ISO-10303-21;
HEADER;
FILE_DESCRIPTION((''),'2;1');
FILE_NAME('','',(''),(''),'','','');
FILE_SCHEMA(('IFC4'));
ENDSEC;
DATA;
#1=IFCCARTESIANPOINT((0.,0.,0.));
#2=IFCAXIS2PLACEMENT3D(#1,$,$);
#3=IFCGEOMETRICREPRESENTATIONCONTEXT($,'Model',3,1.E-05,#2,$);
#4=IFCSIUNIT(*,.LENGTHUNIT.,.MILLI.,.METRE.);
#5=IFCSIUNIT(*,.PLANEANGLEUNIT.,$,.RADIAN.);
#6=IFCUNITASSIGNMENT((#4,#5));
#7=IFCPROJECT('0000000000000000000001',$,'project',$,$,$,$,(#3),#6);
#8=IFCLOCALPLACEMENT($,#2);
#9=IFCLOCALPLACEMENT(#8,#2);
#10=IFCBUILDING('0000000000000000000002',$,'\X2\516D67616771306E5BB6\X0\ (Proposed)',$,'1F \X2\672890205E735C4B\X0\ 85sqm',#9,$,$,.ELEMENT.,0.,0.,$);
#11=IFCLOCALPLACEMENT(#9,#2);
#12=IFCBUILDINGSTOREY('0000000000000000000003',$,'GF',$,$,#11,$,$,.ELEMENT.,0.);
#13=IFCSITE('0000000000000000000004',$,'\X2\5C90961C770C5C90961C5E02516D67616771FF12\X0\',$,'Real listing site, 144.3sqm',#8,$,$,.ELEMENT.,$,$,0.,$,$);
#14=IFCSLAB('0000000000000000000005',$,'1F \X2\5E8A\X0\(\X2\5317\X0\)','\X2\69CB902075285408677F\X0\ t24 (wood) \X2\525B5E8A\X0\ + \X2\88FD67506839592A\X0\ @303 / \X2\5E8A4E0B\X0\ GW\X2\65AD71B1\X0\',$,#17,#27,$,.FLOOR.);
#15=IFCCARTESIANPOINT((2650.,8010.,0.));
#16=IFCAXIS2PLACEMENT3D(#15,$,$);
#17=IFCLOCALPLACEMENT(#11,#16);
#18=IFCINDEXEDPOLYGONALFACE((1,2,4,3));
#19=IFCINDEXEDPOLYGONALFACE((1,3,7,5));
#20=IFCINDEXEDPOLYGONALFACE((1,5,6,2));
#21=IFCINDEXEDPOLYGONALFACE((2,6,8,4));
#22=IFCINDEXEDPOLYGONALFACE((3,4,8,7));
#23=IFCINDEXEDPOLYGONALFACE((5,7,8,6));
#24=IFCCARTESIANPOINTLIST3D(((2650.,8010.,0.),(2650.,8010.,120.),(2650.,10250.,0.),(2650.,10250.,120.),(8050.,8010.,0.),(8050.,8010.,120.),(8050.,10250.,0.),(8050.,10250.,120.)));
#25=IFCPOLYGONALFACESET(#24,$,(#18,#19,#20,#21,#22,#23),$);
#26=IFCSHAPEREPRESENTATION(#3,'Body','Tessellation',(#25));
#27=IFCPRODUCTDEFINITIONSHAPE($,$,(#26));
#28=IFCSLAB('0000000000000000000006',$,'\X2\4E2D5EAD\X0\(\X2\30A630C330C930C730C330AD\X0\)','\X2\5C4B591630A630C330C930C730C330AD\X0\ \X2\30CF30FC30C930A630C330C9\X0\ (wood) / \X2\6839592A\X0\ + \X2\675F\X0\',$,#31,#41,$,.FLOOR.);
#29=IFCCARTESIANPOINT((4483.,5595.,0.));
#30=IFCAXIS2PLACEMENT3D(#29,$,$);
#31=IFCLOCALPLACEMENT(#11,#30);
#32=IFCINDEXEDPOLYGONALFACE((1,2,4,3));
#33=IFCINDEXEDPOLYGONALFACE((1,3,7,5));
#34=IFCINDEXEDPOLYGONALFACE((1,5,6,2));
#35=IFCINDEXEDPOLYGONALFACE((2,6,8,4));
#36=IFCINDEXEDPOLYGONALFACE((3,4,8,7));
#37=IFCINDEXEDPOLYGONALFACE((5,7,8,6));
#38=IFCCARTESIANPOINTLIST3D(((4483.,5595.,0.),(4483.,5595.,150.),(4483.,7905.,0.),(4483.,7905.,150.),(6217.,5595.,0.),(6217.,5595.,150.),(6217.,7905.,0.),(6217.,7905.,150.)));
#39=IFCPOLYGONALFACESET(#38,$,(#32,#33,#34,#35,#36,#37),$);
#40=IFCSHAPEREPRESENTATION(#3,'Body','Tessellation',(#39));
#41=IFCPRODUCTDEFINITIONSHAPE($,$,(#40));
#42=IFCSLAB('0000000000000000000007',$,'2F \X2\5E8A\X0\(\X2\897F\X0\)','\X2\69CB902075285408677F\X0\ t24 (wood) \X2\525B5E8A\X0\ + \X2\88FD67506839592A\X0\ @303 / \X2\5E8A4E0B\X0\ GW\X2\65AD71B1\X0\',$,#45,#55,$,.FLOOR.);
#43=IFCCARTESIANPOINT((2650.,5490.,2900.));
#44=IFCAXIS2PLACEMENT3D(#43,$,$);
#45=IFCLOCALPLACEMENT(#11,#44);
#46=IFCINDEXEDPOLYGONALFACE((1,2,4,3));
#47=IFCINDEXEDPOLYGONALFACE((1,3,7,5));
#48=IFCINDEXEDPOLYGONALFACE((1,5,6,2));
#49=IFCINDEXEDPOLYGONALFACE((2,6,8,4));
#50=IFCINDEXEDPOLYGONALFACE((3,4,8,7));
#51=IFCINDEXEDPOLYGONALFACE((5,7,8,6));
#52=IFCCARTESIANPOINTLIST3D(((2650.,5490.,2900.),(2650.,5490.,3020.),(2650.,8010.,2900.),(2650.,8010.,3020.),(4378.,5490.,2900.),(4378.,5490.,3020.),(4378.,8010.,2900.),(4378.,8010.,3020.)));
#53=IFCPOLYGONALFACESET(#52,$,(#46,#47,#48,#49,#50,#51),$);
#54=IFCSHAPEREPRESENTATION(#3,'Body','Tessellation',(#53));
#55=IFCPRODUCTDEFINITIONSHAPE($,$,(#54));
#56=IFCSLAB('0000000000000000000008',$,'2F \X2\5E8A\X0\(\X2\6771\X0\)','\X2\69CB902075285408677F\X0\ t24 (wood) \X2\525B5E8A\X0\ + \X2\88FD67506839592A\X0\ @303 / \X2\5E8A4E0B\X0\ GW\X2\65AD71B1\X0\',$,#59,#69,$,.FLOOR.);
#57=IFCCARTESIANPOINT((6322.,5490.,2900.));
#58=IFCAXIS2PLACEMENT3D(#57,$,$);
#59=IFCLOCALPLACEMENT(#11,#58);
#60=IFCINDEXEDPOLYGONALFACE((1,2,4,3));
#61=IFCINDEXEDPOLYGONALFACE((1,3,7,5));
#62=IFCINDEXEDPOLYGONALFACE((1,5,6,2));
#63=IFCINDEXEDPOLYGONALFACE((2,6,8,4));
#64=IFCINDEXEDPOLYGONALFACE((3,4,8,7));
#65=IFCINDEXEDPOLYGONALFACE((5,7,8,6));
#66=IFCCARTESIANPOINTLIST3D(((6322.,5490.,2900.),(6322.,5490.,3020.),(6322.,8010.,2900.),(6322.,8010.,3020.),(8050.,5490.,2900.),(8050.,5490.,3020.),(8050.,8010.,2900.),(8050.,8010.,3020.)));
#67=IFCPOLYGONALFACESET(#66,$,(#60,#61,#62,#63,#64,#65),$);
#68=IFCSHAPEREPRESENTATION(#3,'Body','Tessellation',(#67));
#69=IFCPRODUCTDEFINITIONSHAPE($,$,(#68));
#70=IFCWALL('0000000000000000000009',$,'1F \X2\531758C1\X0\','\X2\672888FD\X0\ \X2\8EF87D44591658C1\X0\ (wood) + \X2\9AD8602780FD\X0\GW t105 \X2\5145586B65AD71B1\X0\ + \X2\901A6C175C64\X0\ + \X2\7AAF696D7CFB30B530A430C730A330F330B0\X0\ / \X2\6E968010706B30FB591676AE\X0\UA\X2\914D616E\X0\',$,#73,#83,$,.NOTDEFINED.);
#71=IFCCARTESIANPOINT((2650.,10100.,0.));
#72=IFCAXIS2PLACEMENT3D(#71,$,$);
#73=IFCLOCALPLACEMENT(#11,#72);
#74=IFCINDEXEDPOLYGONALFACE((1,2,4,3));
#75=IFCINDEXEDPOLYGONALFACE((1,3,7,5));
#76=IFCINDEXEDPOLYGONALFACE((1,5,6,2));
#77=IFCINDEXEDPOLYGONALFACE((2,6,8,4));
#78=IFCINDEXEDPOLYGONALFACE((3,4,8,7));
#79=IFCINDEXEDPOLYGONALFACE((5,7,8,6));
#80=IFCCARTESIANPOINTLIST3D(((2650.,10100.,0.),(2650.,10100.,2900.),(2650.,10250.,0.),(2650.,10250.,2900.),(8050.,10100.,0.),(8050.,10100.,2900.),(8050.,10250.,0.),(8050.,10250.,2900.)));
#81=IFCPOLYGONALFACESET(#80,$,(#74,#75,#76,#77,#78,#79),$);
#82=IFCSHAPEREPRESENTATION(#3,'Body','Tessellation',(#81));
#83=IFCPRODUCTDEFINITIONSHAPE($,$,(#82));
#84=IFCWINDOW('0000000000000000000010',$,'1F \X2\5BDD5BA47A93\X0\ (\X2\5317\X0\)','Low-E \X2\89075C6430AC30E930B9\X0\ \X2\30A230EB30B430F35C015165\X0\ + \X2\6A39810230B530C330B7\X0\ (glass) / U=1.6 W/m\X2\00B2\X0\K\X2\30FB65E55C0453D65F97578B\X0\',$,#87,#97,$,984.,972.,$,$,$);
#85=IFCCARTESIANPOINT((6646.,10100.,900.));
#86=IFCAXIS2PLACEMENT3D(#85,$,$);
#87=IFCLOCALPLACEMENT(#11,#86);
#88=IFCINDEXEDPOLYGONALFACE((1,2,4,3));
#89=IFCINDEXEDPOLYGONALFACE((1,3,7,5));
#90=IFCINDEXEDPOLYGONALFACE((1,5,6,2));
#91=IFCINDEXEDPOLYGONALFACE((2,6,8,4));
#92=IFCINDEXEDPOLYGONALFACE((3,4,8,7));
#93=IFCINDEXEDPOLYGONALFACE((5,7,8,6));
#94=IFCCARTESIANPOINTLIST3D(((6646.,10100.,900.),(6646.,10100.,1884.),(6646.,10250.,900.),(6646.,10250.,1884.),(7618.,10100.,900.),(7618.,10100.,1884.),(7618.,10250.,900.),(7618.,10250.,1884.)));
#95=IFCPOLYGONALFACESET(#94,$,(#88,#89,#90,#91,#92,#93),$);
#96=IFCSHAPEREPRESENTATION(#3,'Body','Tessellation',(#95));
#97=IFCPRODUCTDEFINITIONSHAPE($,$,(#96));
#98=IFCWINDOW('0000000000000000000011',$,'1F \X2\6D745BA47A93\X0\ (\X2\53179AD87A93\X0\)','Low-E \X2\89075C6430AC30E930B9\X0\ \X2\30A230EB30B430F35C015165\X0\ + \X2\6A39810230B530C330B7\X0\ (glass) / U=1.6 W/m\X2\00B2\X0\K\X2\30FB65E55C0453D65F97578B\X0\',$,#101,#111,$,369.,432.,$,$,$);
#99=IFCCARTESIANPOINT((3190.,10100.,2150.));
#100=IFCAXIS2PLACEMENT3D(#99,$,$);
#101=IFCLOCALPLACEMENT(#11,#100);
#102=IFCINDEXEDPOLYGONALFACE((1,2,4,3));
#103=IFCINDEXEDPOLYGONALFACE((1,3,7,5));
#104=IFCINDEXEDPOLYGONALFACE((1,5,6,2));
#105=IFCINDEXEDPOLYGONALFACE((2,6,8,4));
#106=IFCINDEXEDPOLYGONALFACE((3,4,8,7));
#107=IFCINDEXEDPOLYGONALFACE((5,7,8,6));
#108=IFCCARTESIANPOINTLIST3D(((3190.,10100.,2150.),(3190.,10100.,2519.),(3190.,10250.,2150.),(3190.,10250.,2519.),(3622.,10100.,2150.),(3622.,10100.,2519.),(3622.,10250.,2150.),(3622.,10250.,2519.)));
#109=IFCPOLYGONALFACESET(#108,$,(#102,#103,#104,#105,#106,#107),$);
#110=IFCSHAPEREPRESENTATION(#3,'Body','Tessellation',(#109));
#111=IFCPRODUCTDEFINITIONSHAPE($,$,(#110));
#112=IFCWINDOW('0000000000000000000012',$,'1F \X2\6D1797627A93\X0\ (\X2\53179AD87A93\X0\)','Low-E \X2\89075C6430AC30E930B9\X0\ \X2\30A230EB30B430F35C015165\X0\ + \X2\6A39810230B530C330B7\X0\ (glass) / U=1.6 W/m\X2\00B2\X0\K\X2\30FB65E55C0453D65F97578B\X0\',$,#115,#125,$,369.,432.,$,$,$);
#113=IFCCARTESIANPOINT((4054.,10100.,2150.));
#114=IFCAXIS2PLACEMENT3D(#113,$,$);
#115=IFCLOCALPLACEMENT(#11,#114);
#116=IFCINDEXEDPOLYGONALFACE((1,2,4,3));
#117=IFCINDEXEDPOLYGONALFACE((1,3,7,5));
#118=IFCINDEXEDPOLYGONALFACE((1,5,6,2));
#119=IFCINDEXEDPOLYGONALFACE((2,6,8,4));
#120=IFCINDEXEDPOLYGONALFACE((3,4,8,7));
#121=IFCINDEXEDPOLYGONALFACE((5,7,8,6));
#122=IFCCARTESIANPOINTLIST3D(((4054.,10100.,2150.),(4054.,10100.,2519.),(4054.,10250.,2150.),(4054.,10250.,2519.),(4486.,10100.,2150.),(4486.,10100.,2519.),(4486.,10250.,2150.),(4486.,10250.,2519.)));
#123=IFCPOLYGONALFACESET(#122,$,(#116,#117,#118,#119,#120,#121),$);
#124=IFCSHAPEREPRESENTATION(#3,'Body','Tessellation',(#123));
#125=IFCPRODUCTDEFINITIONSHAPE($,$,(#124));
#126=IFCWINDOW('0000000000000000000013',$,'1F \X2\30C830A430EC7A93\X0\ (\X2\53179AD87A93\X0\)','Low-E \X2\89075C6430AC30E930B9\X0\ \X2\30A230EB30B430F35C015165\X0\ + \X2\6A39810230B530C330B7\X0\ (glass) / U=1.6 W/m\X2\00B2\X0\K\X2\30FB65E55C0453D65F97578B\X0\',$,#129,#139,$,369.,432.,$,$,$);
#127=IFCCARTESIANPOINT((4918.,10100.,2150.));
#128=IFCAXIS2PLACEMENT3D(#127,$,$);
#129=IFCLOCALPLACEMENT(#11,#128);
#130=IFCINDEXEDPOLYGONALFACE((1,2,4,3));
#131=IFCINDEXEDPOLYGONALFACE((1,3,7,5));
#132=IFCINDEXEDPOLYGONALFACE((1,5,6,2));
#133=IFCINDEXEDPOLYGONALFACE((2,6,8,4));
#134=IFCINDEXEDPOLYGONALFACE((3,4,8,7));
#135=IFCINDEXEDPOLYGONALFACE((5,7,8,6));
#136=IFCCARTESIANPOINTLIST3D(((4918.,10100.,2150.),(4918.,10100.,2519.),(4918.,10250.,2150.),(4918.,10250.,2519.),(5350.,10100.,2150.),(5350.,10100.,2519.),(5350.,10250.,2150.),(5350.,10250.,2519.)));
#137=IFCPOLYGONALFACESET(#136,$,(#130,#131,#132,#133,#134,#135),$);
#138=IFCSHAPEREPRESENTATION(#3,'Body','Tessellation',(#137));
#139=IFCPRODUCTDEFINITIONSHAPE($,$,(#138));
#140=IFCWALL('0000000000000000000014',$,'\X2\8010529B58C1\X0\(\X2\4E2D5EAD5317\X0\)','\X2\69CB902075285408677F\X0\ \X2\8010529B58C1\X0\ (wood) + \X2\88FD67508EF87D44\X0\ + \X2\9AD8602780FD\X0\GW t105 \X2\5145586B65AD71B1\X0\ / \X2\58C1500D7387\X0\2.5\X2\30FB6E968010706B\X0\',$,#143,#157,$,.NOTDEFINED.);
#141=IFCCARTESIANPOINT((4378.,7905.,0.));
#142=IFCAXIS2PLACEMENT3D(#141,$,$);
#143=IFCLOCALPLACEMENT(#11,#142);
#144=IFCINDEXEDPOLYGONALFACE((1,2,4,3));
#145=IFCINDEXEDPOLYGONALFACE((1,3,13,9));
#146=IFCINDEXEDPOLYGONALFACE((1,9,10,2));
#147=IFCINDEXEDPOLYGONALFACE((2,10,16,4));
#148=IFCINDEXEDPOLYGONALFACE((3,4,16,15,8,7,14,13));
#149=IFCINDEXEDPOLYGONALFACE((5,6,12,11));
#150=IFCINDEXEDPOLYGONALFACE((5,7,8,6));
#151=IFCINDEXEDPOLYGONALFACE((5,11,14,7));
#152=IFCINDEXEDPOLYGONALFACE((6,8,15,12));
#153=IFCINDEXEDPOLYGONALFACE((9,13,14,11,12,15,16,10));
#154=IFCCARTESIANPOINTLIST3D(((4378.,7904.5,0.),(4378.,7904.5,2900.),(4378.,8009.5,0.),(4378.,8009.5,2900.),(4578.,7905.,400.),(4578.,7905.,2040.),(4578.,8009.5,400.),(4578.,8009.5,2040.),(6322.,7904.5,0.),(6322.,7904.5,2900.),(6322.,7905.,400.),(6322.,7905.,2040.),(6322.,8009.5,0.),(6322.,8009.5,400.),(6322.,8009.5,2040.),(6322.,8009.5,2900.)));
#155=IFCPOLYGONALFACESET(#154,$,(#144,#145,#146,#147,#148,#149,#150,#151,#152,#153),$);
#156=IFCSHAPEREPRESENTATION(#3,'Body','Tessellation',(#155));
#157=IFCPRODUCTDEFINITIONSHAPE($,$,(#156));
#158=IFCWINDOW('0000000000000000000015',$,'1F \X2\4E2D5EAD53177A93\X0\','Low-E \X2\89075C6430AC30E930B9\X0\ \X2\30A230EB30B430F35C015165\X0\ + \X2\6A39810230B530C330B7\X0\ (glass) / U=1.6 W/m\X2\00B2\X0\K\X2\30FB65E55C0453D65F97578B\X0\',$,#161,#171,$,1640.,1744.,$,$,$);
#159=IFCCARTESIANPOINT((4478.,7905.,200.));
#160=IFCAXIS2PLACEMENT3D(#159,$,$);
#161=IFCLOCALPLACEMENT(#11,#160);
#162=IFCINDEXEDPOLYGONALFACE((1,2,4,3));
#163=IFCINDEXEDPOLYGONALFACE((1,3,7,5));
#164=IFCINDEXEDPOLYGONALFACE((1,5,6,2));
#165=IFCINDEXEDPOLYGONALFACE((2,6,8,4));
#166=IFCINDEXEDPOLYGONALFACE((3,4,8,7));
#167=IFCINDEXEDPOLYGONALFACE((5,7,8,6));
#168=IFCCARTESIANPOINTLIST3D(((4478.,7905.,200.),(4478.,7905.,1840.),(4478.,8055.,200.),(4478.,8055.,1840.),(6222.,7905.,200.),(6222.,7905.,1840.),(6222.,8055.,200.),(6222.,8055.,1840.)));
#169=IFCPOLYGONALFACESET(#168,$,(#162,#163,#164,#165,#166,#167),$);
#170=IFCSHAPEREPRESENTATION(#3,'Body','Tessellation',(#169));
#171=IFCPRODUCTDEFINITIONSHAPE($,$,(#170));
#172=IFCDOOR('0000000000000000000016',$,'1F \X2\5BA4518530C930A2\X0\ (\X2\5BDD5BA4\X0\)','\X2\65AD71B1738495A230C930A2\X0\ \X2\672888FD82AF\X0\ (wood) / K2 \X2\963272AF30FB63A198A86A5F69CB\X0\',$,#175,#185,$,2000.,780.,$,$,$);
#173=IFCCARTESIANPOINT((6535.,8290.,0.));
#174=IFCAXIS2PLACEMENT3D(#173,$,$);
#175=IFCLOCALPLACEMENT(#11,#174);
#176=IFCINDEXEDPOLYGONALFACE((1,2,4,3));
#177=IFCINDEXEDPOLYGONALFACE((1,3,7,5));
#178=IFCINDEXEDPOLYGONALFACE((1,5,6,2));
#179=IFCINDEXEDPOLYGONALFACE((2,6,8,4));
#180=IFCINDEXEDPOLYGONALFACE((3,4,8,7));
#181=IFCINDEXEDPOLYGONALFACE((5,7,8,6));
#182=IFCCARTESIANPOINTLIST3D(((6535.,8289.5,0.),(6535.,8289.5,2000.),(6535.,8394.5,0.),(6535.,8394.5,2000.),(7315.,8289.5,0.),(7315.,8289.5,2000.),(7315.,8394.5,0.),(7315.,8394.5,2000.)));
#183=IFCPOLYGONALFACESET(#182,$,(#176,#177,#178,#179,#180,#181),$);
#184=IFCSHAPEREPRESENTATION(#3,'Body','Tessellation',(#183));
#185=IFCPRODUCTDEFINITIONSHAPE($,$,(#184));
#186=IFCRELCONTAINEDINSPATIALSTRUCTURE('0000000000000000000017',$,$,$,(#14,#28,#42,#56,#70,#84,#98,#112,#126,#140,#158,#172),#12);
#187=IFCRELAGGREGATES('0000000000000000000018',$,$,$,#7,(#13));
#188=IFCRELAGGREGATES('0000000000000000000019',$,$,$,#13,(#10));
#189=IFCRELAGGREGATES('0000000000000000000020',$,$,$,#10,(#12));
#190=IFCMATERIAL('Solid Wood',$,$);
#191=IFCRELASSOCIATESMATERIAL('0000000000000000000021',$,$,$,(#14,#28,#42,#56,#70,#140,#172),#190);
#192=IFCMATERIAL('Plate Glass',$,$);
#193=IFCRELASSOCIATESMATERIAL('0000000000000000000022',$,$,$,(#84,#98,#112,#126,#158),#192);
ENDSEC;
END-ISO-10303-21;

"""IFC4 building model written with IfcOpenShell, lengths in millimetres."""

from ifc_helpers import new_model, si_unit, frame, frame_2d, origin, place, context, project, spatial, rectangle, extrude, material, element, fill, save


model = new_model("IFC4")

# Units and contexts
model_context = context("Model", 3, precision=1e-05, world=origin())
ifc_project = project(units=[si_unit("LENGTHUNIT", "METRE", prefix="MILLI"), si_unit("PLANEANGLEUNIT", "RADIAN")], contexts=[model_context])

# Site, building, storey
site_placement = place(None, origin())
site = spatial("IfcSite", under=ifc_project, at=site_placement, Name="岐阜県岐阜市六条東２", ObjectType="Real listing site, 144.3sqm", CompositionType="ELEMENT", RefElevation=0.0)
building_placement = place(site_placement, origin())
building = spatial("IfcBuilding", under=site, at=building_placement, Name="六条東の家 (Proposed)", ObjectType="1F 木造平屋 85sqm", CompositionType="ELEMENT", ElevationOfRefHeight=0.0, ElevationOfTerrain=0.0)
storey_placement = place(building_placement, origin())
storey = spatial("IfcBuildingStorey", under=building, at=storey_placement, Name="GF", CompositionType="ELEMENT", Elevation=0.0)

# Slabs
ifc_material_1 = material(Name="Solid Wood")
slab_1_placement = place(storey_placement, frame((2650.0, 8010.0, 0.0)))
element("IfcSlab", 1, at=slab_1_placement, inside=storey, material=ifc_material_1, Name="1F 床(北)", Description="構造用合板 t24 (wood) 剛床 + 製材根太 @303 / 床下 GW断熱", PredefinedType="FLOOR", context=model_context, shape_type="SweptSolid", body=[
    extrude(rectangle(XDim=5400.0, YDim=2240.0, at=frame_2d((2700.0, 1120.0))), frame((2650.0, 8010.0, 0.0)), (0.0, 0.0, 1.0), 120.0),
])
slab_2_placement = place(storey_placement, frame((4483.0, 5595.0, 0.0)))
element("IfcSlab", 2, at=slab_2_placement, inside=storey, material=ifc_material_1, Name="中庭(ウッドデッキ)", Description="屋外ウッドデッキ ハードウッド (wood) / 根太 + 束", PredefinedType="FLOOR", context=model_context, shape_type="SweptSolid", body=[
    extrude(rectangle(XDim=1734.0, YDim=2310.0, at=frame_2d((867.0, 1155.0))), frame((4483.0, 5595.0, 0.0)), (0.0, 0.0, 1.0), 150.0),
])
slab_3_placement = place(storey_placement, frame((2650.0, 5490.0, 2900.0)))
element("IfcSlab", 3, at=slab_3_placement, inside=storey, material=ifc_material_1, Name="2F 床(西)", Description="構造用合板 t24 (wood) 剛床 + 製材根太 @303 / 床下 GW断熱", PredefinedType="FLOOR", context=model_context, shape_type="SweptSolid", body=[
    extrude(rectangle(XDim=1728.0, YDim=2520.0, at=frame_2d((864.0, 1260.0))), frame((2650.0, 5490.0, 2900.0)), (0.0, 0.0, 1.0), 120.0),
])
slab_4_placement = place(storey_placement, frame((6322.0, 5490.0, 2900.0)))
element("IfcSlab", 4, at=slab_4_placement, inside=storey, material=ifc_material_1, Name="2F 床(東)", Description="構造用合板 t24 (wood) 剛床 + 製材根太 @303 / 床下 GW断熱", PredefinedType="FLOOR", context=model_context, shape_type="SweptSolid", body=[
    extrude(rectangle(XDim=1728.0, YDim=2520.0, at=frame_2d((864.0, 1260.0))), frame((6322.0, 5490.0, 2900.0)), (0.0, 0.0, 1.0), 120.0),
])

# Wall, openings, windows
wall_1_placement = place(storey_placement, frame((2650.0, 10100.0, 0.0)))
wall_1 = element("IfcWall", 5, at=wall_1_placement, inside=storey, material=ifc_material_1, Name="1F 北壁", Description="木製 軸組外壁 (wood) + 高性能GW t105 充填断熱 + 通気層 + 窯業系サイディング / 準耐火・外皮UA配慮", PredefinedType="NOTDEFINED", context=model_context, shape_type="SweptSolid", body=[
    extrude(rectangle(XDim=5400.0, YDim=150.0, at=frame_2d((2700.0, 75.0))), frame((2650.0, 10100.0, 0.0)), (0.0, 0.0, 1.0), 2900.0),
])
opening_1_placement = place(storey_placement, frame((6646.0, 10100.0, 900.0)))
opening_1 = element("IfcOpeningElement", 6, at=opening_1_placement, cuts=wall_1, PredefinedType="NOTDEFINED", context=model_context, shape_type="SweptSolid", body=[
    extrude(rectangle(XDim=972.0, YDim=150.0, at=frame_2d((486.0, 75.0))), frame((6646.0, 10100.0, 900.0)), (0.0, 0.0, 1.0), 984.0),
])
opening_2_placement = place(storey_placement, frame((3190.0, 10100.0, 2150.0)))
opening_2 = element("IfcOpeningElement", 7, at=opening_2_placement, cuts=wall_1, PredefinedType="NOTDEFINED", context=model_context, shape_type="SweptSolid", body=[
    extrude(rectangle(XDim=432.0, YDim=150.0, at=frame_2d((216.0, 75.0))), frame((3190.0, 10100.0, 2150.0)), (0.0, 0.0, 1.0), 369.0),
])
opening_3_placement = place(storey_placement, frame((4054.0, 10100.0, 2150.0)))
opening_3 = element("IfcOpeningElement", 8, at=opening_3_placement, cuts=wall_1, PredefinedType="NOTDEFINED", context=model_context, shape_type="SweptSolid", body=[
    extrude(rectangle(XDim=432.0, YDim=150.0, at=frame_2d((216.0, 75.0))), frame((4054.0, 10100.0, 2150.0)), (0.0, 0.0, 1.0), 369.0),
])
opening_4_placement = place(storey_placement, frame((4918.0, 10100.0, 2150.0)))
opening_4 = element("IfcOpeningElement", 9, at=opening_4_placement, cuts=wall_1, PredefinedType="NOTDEFINED", context=model_context, shape_type="SweptSolid", body=[
    extrude(rectangle(XDim=432.0, YDim=150.0, at=frame_2d((216.0, 75.0))), frame((4918.0, 10100.0, 2150.0)), (0.0, 0.0, 1.0), 369.0),
])
ifc_material_2 = material(Name="Plate Glass")
window_1_placement = place(storey_placement, frame((6646.0, 10100.0, 900.0)))
window_1 = element("IfcWindow", 10, at=window_1_placement, inside=storey, material=ifc_material_2, Name="1F 寝室窓 (北)", Description="Low-E 複層ガラス アルゴン封入 + 樹脂サッシ (glass) / U=1.6 W/m²K・日射取得型", OverallHeight=984.0, OverallWidth=972.0, context=model_context, shape_type="SweptSolid", body=[
    extrude(rectangle(XDim=972.0, YDim=150.0, at=frame_2d((486.0, 75.0))), frame((6646.0, 10100.0, 900.0)), (0.0, 0.0, 1.0), 984.0),
])
fill(opening_1, window_1)
window_2_placement = place(storey_placement, frame((3190.0, 10100.0, 2150.0)))
window_2 = element("IfcWindow", 11, at=window_2_placement, inside=storey, material=ifc_material_2, Name="1F 浴室窓 (北高窓)", Description="Low-E 複層ガラス アルゴン封入 + 樹脂サッシ (glass) / U=1.6 W/m²K・日射取得型", OverallHeight=369.0, OverallWidth=432.0, context=model_context, shape_type="SweptSolid", body=[
    extrude(rectangle(XDim=432.0, YDim=150.0, at=frame_2d((216.0, 75.0))), frame((3190.0, 10100.0, 2150.0)), (0.0, 0.0, 1.0), 369.0),
])
fill(opening_2, window_2)
window_3_placement = place(storey_placement, frame((4054.0, 10100.0, 2150.0)))
window_3 = element("IfcWindow", 12, at=window_3_placement, inside=storey, material=ifc_material_2, Name="1F 洗面窓 (北高窓)", Description="Low-E 複層ガラス アルゴン封入 + 樹脂サッシ (glass) / U=1.6 W/m²K・日射取得型", OverallHeight=369.0, OverallWidth=432.0, context=model_context, shape_type="SweptSolid", body=[
    extrude(rectangle(XDim=432.0, YDim=150.0, at=frame_2d((216.0, 75.0))), frame((4054.0, 10100.0, 2150.0)), (0.0, 0.0, 1.0), 369.0),
])
fill(opening_3, window_3)
window_4_placement = place(storey_placement, frame((4918.0, 10100.0, 2150.0)))
window_4 = element("IfcWindow", 13, at=window_4_placement, inside=storey, material=ifc_material_2, Name="1F トイレ窓 (北高窓)", Description="Low-E 複層ガラス アルゴン封入 + 樹脂サッシ (glass) / U=1.6 W/m²K・日射取得型", OverallHeight=369.0, OverallWidth=432.0, context=model_context, shape_type="SweptSolid", body=[
    extrude(rectangle(XDim=432.0, YDim=150.0, at=frame_2d((216.0, 75.0))), frame((4918.0, 10100.0, 2150.0)), (0.0, 0.0, 1.0), 369.0),
])
fill(opening_4, window_4)

# Wall, opening, window
wall_2_placement = place(storey_placement, frame((4378.0, 7905.0, 0.0)))
wall_2 = element("IfcWall", 14, at=wall_2_placement, inside=storey, material=ifc_material_1, Name="耐力壁(中庭北)", Description="構造用合板 耐力壁 (wood) + 製材軸組 + 高性能GW t105 充填断熱 / 壁倍率2.5・準耐火", PredefinedType="NOTDEFINED", context=model_context, shape_type="SweptSolid", body=[
    extrude(rectangle(XDim=1944.0, YDim=105.0, at=frame_2d((972.0, 52.0))), frame((4378.0, 7905.0, 0.0)), (0.0, 0.0, 1.0), 2900.0),
])
opening_5_placement = place(storey_placement, frame((4478.0, 7905.0, 200.0)))
opening_5 = element("IfcOpeningElement", 15, at=opening_5_placement, cuts=wall_2, PredefinedType="NOTDEFINED", context=model_context, shape_type="SweptSolid", body=[
    extrude(rectangle(XDim=1744.0, YDim=150.0, at=frame_2d((872.0, 75.0))), frame((4478.0, 7905.0, 200.0)), (0.0, 0.0, 1.0), 1640.0),
])
window_5_placement = place(storey_placement, frame((4478.0, 7905.0, 200.0)))
window_5 = element("IfcWindow", 16, at=window_5_placement, inside=storey, material=ifc_material_2, Name="1F 中庭北窓", Description="Low-E 複層ガラス アルゴン封入 + 樹脂サッシ (glass) / U=1.6 W/m²K・日射取得型", OverallHeight=1640.0, OverallWidth=1744.0, context=model_context, shape_type="SweptSolid", body=[
    extrude(rectangle(XDim=1744.0, YDim=150.0, at=frame_2d((872.0, 75.0))), frame((4478.0, 7905.0, 200.0)), (0.0, 0.0, 1.0), 1640.0),
])
fill(opening_5, window_5)

# Door
door_1_placement = place(storey_placement, frame((6535.0, 8290.0, 0.0)))
element("IfcDoor", 17, at=door_1_placement, inside=storey, material=ifc_material_1, Name="1F 室内ドア (寝室)", Description="断熱玄関ドア 木製芯 (wood) / K2 防犯・採風機構", OverallHeight=2000.0, OverallWidth=780.0, context=model_context, shape_type="SweptSolid", body=[
    extrude(rectangle(XDim=780.0, YDim=105.0, at=frame_2d((390.0, 52.0))), frame((6535.0, 8290.0, 0.0)), (0.0, 0.0, 1.0), 2000.0),
])

save(model, "model.ifc")
